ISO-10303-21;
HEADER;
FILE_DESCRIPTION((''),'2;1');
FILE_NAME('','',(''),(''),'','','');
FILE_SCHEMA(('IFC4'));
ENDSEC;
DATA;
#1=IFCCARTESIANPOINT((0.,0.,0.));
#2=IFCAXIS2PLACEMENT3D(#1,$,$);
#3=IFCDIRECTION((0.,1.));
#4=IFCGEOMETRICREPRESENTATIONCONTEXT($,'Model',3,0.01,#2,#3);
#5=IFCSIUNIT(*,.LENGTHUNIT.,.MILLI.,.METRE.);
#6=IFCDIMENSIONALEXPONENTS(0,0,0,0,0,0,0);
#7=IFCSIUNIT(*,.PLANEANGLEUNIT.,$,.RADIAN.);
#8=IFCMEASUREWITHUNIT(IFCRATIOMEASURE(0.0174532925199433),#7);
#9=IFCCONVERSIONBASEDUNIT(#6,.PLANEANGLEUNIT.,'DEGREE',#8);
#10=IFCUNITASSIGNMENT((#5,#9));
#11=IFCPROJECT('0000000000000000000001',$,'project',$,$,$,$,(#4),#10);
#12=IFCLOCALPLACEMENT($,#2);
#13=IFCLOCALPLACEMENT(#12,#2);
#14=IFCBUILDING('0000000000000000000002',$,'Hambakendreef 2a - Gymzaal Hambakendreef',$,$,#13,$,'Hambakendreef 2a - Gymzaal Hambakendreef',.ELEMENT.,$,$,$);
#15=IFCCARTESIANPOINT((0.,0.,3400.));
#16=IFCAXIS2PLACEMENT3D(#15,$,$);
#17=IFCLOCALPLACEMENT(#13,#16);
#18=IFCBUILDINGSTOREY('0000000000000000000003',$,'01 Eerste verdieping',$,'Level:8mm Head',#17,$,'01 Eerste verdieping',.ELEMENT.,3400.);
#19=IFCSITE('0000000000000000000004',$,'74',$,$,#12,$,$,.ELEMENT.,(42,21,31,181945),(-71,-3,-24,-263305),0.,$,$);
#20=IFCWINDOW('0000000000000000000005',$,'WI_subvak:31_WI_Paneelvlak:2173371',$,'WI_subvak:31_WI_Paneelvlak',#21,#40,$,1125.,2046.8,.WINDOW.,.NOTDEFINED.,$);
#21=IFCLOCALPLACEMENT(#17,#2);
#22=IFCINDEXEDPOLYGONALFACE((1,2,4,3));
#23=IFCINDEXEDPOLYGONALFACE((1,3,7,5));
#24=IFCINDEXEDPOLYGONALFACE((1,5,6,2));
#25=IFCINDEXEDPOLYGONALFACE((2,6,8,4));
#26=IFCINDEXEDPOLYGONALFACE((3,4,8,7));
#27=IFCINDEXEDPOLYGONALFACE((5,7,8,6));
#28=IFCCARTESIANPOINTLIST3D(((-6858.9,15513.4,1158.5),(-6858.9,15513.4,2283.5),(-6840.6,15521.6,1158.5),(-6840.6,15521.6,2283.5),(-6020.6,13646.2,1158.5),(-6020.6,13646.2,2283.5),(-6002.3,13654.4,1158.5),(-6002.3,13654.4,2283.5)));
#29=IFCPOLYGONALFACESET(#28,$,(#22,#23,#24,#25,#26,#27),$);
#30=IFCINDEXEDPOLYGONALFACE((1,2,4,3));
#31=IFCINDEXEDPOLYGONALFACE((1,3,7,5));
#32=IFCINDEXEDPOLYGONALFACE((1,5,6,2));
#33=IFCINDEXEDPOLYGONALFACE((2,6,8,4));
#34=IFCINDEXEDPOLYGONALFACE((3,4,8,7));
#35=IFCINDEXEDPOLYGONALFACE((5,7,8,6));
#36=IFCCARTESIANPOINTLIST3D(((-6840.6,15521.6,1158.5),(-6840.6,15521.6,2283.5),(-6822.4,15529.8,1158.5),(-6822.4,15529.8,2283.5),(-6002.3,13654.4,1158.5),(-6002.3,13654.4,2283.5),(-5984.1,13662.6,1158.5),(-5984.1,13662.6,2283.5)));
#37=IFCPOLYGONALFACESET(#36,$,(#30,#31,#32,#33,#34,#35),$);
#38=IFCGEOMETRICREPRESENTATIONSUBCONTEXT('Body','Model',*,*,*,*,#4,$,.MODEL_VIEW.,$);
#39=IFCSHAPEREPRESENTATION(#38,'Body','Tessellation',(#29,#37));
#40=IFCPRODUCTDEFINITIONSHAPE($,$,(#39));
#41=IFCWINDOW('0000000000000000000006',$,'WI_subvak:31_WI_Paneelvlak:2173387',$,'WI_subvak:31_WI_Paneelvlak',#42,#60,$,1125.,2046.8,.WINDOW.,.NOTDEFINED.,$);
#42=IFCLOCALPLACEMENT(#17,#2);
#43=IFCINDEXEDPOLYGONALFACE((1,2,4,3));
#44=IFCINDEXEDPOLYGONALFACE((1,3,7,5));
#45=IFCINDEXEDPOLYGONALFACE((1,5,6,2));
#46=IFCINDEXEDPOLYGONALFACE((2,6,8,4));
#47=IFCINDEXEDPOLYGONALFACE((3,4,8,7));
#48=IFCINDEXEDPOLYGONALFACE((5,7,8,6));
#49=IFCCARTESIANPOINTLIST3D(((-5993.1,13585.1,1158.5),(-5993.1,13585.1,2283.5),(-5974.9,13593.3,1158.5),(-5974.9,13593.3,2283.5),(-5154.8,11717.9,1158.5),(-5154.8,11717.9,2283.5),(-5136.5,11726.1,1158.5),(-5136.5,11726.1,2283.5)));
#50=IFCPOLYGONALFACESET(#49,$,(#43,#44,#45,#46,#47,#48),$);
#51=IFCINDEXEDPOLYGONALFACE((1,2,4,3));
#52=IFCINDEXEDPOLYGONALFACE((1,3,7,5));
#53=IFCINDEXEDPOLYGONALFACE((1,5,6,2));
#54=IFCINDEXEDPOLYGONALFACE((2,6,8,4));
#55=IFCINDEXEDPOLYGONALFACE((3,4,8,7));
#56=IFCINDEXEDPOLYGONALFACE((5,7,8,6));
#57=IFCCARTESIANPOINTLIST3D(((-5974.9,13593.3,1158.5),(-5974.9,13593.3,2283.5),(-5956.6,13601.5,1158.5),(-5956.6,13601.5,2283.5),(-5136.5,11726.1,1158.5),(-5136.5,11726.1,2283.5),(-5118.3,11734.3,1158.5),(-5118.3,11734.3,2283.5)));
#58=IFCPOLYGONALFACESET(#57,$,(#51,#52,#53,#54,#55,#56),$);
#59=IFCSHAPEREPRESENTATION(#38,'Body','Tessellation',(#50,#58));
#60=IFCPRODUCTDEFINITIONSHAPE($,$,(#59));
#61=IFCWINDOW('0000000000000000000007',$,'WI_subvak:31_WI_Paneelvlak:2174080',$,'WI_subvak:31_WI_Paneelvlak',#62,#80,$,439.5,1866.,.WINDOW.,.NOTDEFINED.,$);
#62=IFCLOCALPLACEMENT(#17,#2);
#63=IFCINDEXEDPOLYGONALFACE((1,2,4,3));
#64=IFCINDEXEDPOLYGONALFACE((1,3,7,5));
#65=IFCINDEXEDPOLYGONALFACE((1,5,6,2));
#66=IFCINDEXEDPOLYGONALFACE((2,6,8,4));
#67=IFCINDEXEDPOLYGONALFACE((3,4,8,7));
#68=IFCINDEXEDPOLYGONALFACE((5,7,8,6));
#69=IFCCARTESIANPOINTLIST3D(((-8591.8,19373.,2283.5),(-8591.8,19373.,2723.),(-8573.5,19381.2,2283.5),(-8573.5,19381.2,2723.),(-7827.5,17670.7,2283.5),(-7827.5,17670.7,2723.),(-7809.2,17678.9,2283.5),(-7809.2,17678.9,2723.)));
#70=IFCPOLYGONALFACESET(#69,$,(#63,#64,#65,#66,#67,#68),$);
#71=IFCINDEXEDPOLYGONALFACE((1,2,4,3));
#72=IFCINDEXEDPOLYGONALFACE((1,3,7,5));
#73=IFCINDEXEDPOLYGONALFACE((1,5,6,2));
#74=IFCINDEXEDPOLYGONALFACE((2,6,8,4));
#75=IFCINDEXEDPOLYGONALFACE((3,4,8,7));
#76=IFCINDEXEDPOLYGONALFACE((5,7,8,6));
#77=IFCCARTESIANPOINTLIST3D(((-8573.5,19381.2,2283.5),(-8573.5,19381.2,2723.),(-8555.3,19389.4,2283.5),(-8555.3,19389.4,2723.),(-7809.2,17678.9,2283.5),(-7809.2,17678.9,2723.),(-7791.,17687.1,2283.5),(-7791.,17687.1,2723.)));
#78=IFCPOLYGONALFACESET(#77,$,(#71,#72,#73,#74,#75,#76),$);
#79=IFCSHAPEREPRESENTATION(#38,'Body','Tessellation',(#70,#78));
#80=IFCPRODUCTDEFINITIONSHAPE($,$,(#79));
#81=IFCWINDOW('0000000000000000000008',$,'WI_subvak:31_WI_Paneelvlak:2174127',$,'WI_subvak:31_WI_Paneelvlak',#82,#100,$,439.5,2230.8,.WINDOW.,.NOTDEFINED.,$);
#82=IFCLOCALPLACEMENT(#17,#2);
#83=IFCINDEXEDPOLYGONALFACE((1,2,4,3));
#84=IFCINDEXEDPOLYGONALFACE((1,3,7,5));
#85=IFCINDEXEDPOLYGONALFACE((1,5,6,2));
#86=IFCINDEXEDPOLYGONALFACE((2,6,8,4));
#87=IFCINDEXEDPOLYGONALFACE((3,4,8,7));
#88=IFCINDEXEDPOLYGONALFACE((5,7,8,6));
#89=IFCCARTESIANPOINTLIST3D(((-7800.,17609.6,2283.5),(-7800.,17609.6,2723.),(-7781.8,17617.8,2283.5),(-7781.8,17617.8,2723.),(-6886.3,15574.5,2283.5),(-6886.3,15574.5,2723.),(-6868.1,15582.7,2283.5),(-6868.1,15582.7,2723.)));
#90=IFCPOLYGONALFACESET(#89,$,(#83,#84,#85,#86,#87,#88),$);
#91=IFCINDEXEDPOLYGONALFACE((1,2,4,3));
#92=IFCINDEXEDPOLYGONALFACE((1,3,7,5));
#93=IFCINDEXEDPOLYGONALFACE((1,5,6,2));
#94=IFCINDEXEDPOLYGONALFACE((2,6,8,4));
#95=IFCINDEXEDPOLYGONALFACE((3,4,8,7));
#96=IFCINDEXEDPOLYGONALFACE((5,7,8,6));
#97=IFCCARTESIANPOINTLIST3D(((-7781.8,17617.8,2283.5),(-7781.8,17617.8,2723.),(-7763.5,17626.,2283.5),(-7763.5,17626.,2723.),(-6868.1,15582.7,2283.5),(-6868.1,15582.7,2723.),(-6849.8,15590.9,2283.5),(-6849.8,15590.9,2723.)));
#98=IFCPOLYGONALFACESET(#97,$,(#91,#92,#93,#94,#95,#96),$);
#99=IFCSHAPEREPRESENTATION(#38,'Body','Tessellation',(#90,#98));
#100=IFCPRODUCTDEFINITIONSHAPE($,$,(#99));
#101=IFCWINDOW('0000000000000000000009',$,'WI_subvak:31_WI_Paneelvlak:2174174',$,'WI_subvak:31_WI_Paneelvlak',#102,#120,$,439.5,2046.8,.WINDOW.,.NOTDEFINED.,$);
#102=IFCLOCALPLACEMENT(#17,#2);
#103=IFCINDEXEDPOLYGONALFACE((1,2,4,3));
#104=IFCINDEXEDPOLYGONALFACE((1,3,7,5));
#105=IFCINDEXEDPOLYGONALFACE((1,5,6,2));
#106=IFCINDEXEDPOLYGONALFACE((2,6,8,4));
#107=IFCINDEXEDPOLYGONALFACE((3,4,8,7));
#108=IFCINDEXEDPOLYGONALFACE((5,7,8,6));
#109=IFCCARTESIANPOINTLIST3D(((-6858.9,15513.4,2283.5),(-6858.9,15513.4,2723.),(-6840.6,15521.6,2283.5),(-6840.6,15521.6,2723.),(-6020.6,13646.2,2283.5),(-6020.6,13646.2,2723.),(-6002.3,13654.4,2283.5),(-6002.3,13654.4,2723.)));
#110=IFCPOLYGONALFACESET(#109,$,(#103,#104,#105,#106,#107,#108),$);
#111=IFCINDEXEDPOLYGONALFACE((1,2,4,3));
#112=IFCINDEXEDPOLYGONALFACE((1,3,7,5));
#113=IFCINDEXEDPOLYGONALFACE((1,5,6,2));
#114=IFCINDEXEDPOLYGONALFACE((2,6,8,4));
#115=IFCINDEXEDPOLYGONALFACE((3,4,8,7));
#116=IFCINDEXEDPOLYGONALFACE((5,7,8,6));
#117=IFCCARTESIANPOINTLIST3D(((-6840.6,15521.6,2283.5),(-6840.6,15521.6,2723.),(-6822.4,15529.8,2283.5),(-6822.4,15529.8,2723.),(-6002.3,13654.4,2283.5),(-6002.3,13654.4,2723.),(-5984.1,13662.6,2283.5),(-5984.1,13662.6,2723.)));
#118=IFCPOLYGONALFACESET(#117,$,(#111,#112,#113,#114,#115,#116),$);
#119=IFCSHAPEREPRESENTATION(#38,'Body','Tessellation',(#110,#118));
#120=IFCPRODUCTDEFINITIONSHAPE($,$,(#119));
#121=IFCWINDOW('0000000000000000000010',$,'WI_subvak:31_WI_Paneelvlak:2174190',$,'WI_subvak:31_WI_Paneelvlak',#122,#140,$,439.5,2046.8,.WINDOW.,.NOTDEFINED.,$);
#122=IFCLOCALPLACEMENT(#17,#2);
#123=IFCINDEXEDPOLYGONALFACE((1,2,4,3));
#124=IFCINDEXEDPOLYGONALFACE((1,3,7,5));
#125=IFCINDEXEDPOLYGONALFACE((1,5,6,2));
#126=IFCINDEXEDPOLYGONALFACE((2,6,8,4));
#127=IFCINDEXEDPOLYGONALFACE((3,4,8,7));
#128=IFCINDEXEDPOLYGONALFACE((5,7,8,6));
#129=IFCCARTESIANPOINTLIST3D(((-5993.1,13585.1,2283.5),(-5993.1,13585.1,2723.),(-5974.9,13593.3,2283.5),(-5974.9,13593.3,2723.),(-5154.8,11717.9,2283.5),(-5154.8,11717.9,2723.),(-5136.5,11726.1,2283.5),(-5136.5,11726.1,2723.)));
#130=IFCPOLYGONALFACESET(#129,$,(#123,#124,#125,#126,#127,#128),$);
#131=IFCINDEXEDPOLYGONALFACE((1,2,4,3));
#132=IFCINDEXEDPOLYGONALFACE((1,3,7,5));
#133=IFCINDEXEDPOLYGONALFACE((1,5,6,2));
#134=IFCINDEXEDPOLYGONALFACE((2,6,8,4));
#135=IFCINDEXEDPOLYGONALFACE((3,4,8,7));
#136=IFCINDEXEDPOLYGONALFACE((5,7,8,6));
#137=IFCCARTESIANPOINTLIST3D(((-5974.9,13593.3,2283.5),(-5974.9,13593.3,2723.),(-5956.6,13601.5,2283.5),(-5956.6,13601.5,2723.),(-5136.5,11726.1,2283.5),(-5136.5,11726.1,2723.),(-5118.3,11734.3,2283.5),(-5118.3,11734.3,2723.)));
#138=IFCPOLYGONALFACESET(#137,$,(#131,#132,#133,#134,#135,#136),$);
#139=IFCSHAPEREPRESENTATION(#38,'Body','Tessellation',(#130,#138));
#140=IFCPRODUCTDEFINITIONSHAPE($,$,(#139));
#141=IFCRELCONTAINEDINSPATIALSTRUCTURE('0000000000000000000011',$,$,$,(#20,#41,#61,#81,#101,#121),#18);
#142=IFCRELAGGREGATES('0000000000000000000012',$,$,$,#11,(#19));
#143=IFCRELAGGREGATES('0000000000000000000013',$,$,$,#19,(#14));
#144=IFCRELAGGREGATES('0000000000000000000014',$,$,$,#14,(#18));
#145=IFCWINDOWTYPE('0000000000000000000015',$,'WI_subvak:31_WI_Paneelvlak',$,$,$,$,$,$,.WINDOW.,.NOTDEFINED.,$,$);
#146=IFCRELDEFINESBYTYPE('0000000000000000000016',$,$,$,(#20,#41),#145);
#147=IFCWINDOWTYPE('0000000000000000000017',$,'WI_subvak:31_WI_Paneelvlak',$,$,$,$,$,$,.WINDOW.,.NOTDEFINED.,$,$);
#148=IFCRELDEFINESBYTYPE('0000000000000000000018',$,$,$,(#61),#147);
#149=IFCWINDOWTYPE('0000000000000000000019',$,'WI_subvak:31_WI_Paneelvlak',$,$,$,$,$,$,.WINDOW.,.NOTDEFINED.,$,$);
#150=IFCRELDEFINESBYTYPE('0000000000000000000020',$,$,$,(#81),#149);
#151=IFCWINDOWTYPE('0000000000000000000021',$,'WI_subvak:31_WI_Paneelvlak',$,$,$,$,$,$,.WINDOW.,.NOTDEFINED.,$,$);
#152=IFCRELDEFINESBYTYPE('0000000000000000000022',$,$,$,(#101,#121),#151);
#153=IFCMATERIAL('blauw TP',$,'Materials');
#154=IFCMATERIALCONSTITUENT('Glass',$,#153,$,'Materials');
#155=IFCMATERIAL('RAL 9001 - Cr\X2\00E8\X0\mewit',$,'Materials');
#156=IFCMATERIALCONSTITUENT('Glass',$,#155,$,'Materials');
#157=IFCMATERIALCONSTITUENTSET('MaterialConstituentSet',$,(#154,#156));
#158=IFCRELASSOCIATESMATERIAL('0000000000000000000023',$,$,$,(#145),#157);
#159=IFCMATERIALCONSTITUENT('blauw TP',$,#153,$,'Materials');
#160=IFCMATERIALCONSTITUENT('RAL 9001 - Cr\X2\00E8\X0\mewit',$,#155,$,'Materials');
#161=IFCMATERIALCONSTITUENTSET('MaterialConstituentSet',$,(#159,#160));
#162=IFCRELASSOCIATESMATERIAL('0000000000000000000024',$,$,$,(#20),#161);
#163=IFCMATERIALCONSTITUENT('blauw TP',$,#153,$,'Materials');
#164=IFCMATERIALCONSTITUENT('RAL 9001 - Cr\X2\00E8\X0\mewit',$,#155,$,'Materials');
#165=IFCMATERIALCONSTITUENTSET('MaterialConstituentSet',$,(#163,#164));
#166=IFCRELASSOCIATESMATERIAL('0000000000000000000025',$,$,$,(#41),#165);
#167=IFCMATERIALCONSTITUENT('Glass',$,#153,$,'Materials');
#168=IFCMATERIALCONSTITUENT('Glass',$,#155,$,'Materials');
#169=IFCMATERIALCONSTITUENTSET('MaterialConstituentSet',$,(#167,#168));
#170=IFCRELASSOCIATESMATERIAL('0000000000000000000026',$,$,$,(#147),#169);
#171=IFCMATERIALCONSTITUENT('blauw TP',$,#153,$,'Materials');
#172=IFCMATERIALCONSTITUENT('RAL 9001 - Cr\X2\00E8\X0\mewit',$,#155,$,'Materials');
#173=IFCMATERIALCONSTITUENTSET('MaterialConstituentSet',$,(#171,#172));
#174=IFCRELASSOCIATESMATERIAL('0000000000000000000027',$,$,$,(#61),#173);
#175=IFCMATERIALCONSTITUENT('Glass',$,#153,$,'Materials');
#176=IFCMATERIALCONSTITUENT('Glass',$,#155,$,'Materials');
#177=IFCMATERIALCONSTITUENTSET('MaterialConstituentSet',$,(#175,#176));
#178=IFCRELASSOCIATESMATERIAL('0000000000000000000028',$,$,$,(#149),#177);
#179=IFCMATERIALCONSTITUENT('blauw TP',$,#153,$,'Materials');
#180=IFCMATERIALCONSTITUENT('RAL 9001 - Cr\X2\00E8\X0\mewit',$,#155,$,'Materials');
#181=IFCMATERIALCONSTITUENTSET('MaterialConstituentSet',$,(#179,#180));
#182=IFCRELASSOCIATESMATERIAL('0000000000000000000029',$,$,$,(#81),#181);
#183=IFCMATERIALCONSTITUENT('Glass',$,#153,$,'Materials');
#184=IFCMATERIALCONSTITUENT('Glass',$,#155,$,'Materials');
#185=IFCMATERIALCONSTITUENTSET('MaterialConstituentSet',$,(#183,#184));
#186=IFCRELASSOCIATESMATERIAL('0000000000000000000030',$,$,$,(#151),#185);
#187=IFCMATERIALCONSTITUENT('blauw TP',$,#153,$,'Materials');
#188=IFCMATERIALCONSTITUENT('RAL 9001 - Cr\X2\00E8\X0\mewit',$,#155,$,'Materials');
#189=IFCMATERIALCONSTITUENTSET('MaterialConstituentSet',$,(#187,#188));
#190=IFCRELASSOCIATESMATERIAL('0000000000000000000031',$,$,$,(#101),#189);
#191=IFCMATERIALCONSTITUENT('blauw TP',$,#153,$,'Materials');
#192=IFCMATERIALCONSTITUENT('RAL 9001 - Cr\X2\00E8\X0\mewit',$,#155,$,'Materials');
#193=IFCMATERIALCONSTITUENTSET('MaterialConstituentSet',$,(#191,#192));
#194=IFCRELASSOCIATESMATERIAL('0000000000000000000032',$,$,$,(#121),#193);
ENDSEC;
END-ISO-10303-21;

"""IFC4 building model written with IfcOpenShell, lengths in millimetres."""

from ifc_helpers import new_model, entity, si_unit, converted_unit, direction, frame, origin, place, context, subcontext, project, spatial, indexed_curve, outline, extrude, source, transform, mapped, material, constituent, constituent_set, type_object, type_shapes, element, save


model = new_model("IFC4")

# Units and contexts
model_context = context("Model", 3, precision=0.01, world=origin(), true_north=direction((0.0, 1.0)))
body_context = subcontext(model_context, "Body", "Model", "MODEL_VIEW")
ifc_project = project(units=[si_unit("LENGTHUNIT", "METRE", prefix="MILLI"), converted_unit("PLANEANGLEUNIT", "DEGREE", entity("IfcRatioMeasure", 0.0174532925199433), si_unit("PLANEANGLEUNIT", "RADIAN"), dimensions=[0, 0, 0, 0, 0, 0, 0])], contexts=[model_context])

# Site, building, storey
site_placement = place(None, origin())
site = spatial("IfcSite", under=ifc_project, at=site_placement, Name="74", CompositionType="ELEMENT", RefLatitude=(42, 21, 31, 181945), RefLongitude=(-71, -3, -24, -263305), RefElevation=0.0)
building_placement = place(site_placement, origin())
building = spatial("IfcBuilding", under=site, at=building_placement, Name="Hambakendreef 2a - Gymzaal Hambakendreef", LongName="Hambakendreef 2a - Gymzaal Hambakendreef", CompositionType="ELEMENT")
storey_placement = place(building_placement, frame((0.0, 0.0, 3400.0)))
storey = spatial("IfcBuildingStorey", under=building, at=storey_placement, Name="01 Eerste verdieping", ObjectType="Level:8mm Head", LongName="01 Eerste verdieping", CompositionType="ELEMENT", Elevation=3400.0)

# Windows
ifc_material_1 = material(Name="blauw TP", Category="Materials")
ifc_material_2 = material(Name="RAL 9001 - Crèmewit", Category="Materials")
ifc_constituent_1 = constituent(ifc_material_1, Name="blauw TP", Category="Materials")
ifc_constituent_2 = constituent(ifc_material_2, Name="RAL 9001 - Crèmewit", Category="Materials")
ifc_constituent_set_1 = constituent_set(constituents=[ifc_constituent_1, ifc_constituent_2], Name="MaterialConstituentSet")
ifc_constituent_3 = constituent(ifc_material_1, Name="Glass", Category="Materials")
ifc_constituent_4 = constituent(ifc_material_2, Name="Glass", Category="Materials")
ifc_constituent_set_2 = constituent_set(constituents=[ifc_constituent_3, ifc_constituent_4], Name="MaterialConstituentSet")
window_type_1 = type_object("IfcWindowType", Name="WI_subvak:31_WI_Paneelvlak", PartitioningType="NOTDEFINED", PredefinedType="WINDOW", material=ifc_constituent_set_2)
shared_shape_1 = source(origin(), body_context, "Body", "SweptSolid", [
    extrude(outline(indexed_curve([(-1023.4, -10.0), (1023.4, -10.0), (1023.4, 10.0), (-1023.4, 10.0), (-1023.4, -10.0)], self_intersect=False)), frame((0.0, -10.0, 0.0)), (0.0, 0.0, 1.0), 1125.0),
    extrude(outline(indexed_curve([(-1023.4, -10.0), (1023.4, -10.0), (1023.4, 10.0), (-1023.4, 10.0), (-1023.4, -10.0)], self_intersect=False)), frame((0.0, 10.0, 0.0)), (0.0, 0.0, 1.0), 1125.0),
])
type_shapes(window_type_1, [shared_shape_1])
window_1_placement = place(storey_placement, frame((-6421.5, 14588.0, 1158.5), z_axis=(0.0, 0.0, 1.0), x_axis=(0.40959, -0.91227, 0.0)))
element("IfcWindow", 1, at=window_1_placement, inside=storey, type_object=window_type_1, material=ifc_constituent_set_1, Name="WI_subvak:31_WI_Paneelvlak:2173371", ObjectType="WI_subvak:31_WI_Paneelvlak", OverallHeight=1125.0, OverallWidth=2046.8, PartitioningType="NOTDEFINED", PredefinedType="WINDOW", context=body_context, shape_type="MappedRepresentation", body=[
    mapped(shared_shape_1, transform((0.0, 0.0, 0.0), scale=1.0)),
])
ifc_constituent_5 = constituent(ifc_material_1, Name="blauw TP", Category="Materials")
ifc_constituent_6 = constituent(ifc_material_2, Name="RAL 9001 - Crèmewit", Category="Materials")
ifc_constituent_set_3 = constituent_set(constituents=[ifc_constituent_5, ifc_constituent_6], Name="MaterialConstituentSet")
window_2_placement = place(storey_placement, frame((-5555.7, 12659.7, 1158.5), z_axis=(0.0, 0.0, 1.0), x_axis=(0.40959, -0.91227, 0.0)))
element("IfcWindow", 2, at=window_2_placement, inside=storey, type_object=window_type_1, material=ifc_constituent_set_3, Name="WI_subvak:31_WI_Paneelvlak:2173387", ObjectType="WI_subvak:31_WI_Paneelvlak", OverallHeight=1125.0, OverallWidth=2046.8, PartitioningType="NOTDEFINED", PredefinedType="WINDOW", context=body_context, shape_type="MappedRepresentation", body=[
    mapped(shared_shape_1, transform((0.0, 0.0, 0.0), scale=1.0)),
])
ifc_constituent_7 = constituent(ifc_material_1, Name="blauw TP", Category="Materials")
ifc_constituent_8 = constituent(ifc_material_2, Name="RAL 9001 - Crèmewit", Category="Materials")
ifc_constituent_set_4 = constituent_set(constituents=[ifc_constituent_7, ifc_constituent_8], Name="MaterialConstituentSet")
ifc_constituent_9 = constituent(ifc_material_1, Name="Glass", Category="Materials")
ifc_constituent_10 = constituent(ifc_material_2, Name="Glass", Category="Materials")
ifc_constituent_set_5 = constituent_set(constituents=[ifc_constituent_9, ifc_constituent_10], Name="MaterialConstituentSet")
window_type_2 = type_object("IfcWindowType", Name="WI_subvak:31_WI_Paneelvlak", PartitioningType="NOTDEFINED", PredefinedType="WINDOW", material=ifc_constituent_set_5)
shared_shape_2 = source(origin(), body_context, "Body", "SweptSolid", [
    extrude(outline(indexed_curve([(-933.0, -10.0), (933.0, -10.0), (933.0, 10.0), (-933.0, 10.0), (-933.0, -10.0)], self_intersect=False)), frame((0.0, -10.0, 0.0)), (0.0, 0.0, 1.0), 439.5),
    extrude(outline(indexed_curve([(-933.0, -10.0), (933.0, -10.0), (933.0, 10.0), (-933.0, 10.0), (-933.0, -10.0)], self_intersect=False)), frame((0.0, 10.0, 0.0)), (0.0, 0.0, 1.0), 439.5),
])
type_shapes(window_type_2, [shared_shape_2])
window_3_placement = place(storey_placement, frame((-8191.4, 18530.0, 2283.5), z_axis=(0.0, 0.0, 1.0), x_axis=(0.40959, -0.91227, 0.0)))
element("IfcWindow", 3, at=window_3_placement, inside=storey, type_object=window_type_2, material=ifc_constituent_set_4, Name="WI_subvak:31_WI_Paneelvlak:2174080", ObjectType="WI_subvak:31_WI_Paneelvlak", OverallHeight=439.5, OverallWidth=1866.0, PartitioningType="NOTDEFINED", PredefinedType="WINDOW", context=body_context, shape_type="MappedRepresentation", body=[
    mapped(shared_shape_2, transform((0.0, 0.0, 0.0), scale=1.0)),
])
ifc_constituent_11 = constituent(ifc_material_1, Name="blauw TP", Category="Materials")
ifc_constituent_12 = constituent(ifc_material_2, Name="RAL 9001 - Crèmewit", Category="Materials")
ifc_constituent_set_6 = constituent_set(constituents=[ifc_constituent_11, ifc_constituent_12], Name="MaterialConstituentSet")
ifc_constituent_13 = constituent(ifc_material_1, Name="Glass", Category="Materials")
ifc_constituent_14 = constituent(ifc_material_2, Name="Glass", Category="Materials")
ifc_constituent_set_7 = constituent_set(constituents=[ifc_constituent_13, ifc_constituent_14], Name="MaterialConstituentSet")
window_type_3 = type_object("IfcWindowType", Name="WI_subvak:31_WI_Paneelvlak", PartitioningType="NOTDEFINED", PredefinedType="WINDOW", material=ifc_constituent_set_7)
shared_shape_3 = source(origin(), body_context, "Body", "SweptSolid", [
    extrude(outline(indexed_curve([(-1115.4, -10.0), (1115.4, -10.0), (1115.4, 10.0), (-1115.4, 10.0), (-1115.4, -10.0)], self_intersect=False)), frame((0.0, -10.0, 0.0)), (0.0, 0.0, 1.0), 439.5),
    extrude(outline(indexed_curve([(-1115.4, -10.0), (1115.4, -10.0), (1115.4, 10.0), (-1115.4, 10.0), (-1115.4, -10.0)], self_intersect=False)), frame((0.0, 10.0, 0.0)), (0.0, 0.0, 1.0), 439.5),
])
type_shapes(window_type_3, [shared_shape_3])
window_4_placement = place(storey_placement, frame((-7324.9, 16600.3, 2283.5), z_axis=(0.0, 0.0, 1.0), x_axis=(0.40959, -0.91227, 0.0)))
element("IfcWindow", 4, at=window_4_placement, inside=storey, type_object=window_type_3, material=ifc_constituent_set_6, Name="WI_subvak:31_WI_Paneelvlak:2174127", ObjectType="WI_subvak:31_WI_Paneelvlak", OverallHeight=439.5, OverallWidth=2230.8, PartitioningType="NOTDEFINED", PredefinedType="WINDOW", context=body_context, shape_type="MappedRepresentation", body=[
    mapped(shared_shape_3, transform((0.0, 0.0, 0.0), scale=1.0)),
])
ifc_constituent_15 = constituent(ifc_material_1, Name="blauw TP", Category="Materials")
ifc_constituent_16 = constituent(ifc_material_2, Name="RAL 9001 - Crèmewit", Category="Materials")
ifc_constituent_set_8 = constituent_set(constituents=[ifc_constituent_15, ifc_constituent_16], Name="MaterialConstituentSet")
ifc_constituent_17 = constituent(ifc_material_1, Name="Glass", Category="Materials")
ifc_constituent_18 = constituent(ifc_material_2, Name="Glass", Category="Materials")
ifc_constituent_set_9 = constituent_set(constituents=[ifc_constituent_17, ifc_constituent_18], Name="MaterialConstituentSet")
window_type_4 = type_object("IfcWindowType", Name="WI_subvak:31_WI_Paneelvlak", PartitioningType="NOTDEFINED", PredefinedType="WINDOW", material=ifc_constituent_set_9)
shared_shape_4 = source(origin(), body_context, "Body", "SweptSolid", [
    extrude(outline(indexed_curve([(-1023.4, -10.0), (1023.4, -10.0), (1023.4, 10.0), (-1023.4, 10.0), (-1023.4, -10.0)], self_intersect=False)), frame((0.0, -10.0, 0.0)), (0.0, 0.0, 1.0), 439.5),
    extrude(outline(indexed_curve([(-1023.4, -10.0), (1023.4, -10.0), (1023.4, 10.0), (-1023.4, 10.0), (-1023.4, -10.0)], self_intersect=False)), frame((0.0, 10.0, 0.0)), (0.0, 0.0, 1.0), 439.5),
])
type_shapes(window_type_4, [shared_shape_4])
window_5_placement = place(storey_placement, frame((-6421.5, 14588.0, 2283.5), z_axis=(0.0, 0.0, 1.0), x_axis=(0.40959, -0.91227, 0.0)))
element("IfcWindow", 5, at=window_5_placement, inside=storey, type_object=window_type_4, material=ifc_constituent_set_8, Name="WI_subvak:31_WI_Paneelvlak:2174174", ObjectType="WI_subvak:31_WI_Paneelvlak", OverallHeight=439.5, OverallWidth=2046.8, PartitioningType="NOTDEFINED", PredefinedType="WINDOW", context=body_context, shape_type="MappedRepresentation", body=[
    mapped(shared_shape_4, transform((0.0, 0.0, 0.0), scale=1.0)),
])
ifc_constituent_19 = constituent(ifc_material_1, Name="blauw TP", Category="Materials")
ifc_constituent_20 = constituent(ifc_material_2, Name="RAL 9001 - Crèmewit", Category="Materials")
ifc_constituent_set_10 = constituent_set(constituents=[ifc_constituent_19, ifc_constituent_20], Name="MaterialConstituentSet")
window_6_placement = place(storey_placement, frame((-5555.7, 12659.7, 2283.5), z_axis=(0.0, 0.0, 1.0), x_axis=(0.40959, -0.91227, 0.0)))
element("IfcWindow", 6, at=window_6_placement, inside=storey, type_object=window_type_4, material=ifc_constituent_set_10, Name="WI_subvak:31_WI_Paneelvlak:2174190", ObjectType="WI_subvak:31_WI_Paneelvlak", OverallHeight=439.5, OverallWidth=2046.8, PartitioningType="NOTDEFINED", PredefinedType="WINDOW", context=body_context, shape_type="MappedRepresentation", body=[
    mapped(shared_shape_4, transform((0.0, 0.0, 0.0), scale=1.0)),
])

save(model, "model.ifc")
